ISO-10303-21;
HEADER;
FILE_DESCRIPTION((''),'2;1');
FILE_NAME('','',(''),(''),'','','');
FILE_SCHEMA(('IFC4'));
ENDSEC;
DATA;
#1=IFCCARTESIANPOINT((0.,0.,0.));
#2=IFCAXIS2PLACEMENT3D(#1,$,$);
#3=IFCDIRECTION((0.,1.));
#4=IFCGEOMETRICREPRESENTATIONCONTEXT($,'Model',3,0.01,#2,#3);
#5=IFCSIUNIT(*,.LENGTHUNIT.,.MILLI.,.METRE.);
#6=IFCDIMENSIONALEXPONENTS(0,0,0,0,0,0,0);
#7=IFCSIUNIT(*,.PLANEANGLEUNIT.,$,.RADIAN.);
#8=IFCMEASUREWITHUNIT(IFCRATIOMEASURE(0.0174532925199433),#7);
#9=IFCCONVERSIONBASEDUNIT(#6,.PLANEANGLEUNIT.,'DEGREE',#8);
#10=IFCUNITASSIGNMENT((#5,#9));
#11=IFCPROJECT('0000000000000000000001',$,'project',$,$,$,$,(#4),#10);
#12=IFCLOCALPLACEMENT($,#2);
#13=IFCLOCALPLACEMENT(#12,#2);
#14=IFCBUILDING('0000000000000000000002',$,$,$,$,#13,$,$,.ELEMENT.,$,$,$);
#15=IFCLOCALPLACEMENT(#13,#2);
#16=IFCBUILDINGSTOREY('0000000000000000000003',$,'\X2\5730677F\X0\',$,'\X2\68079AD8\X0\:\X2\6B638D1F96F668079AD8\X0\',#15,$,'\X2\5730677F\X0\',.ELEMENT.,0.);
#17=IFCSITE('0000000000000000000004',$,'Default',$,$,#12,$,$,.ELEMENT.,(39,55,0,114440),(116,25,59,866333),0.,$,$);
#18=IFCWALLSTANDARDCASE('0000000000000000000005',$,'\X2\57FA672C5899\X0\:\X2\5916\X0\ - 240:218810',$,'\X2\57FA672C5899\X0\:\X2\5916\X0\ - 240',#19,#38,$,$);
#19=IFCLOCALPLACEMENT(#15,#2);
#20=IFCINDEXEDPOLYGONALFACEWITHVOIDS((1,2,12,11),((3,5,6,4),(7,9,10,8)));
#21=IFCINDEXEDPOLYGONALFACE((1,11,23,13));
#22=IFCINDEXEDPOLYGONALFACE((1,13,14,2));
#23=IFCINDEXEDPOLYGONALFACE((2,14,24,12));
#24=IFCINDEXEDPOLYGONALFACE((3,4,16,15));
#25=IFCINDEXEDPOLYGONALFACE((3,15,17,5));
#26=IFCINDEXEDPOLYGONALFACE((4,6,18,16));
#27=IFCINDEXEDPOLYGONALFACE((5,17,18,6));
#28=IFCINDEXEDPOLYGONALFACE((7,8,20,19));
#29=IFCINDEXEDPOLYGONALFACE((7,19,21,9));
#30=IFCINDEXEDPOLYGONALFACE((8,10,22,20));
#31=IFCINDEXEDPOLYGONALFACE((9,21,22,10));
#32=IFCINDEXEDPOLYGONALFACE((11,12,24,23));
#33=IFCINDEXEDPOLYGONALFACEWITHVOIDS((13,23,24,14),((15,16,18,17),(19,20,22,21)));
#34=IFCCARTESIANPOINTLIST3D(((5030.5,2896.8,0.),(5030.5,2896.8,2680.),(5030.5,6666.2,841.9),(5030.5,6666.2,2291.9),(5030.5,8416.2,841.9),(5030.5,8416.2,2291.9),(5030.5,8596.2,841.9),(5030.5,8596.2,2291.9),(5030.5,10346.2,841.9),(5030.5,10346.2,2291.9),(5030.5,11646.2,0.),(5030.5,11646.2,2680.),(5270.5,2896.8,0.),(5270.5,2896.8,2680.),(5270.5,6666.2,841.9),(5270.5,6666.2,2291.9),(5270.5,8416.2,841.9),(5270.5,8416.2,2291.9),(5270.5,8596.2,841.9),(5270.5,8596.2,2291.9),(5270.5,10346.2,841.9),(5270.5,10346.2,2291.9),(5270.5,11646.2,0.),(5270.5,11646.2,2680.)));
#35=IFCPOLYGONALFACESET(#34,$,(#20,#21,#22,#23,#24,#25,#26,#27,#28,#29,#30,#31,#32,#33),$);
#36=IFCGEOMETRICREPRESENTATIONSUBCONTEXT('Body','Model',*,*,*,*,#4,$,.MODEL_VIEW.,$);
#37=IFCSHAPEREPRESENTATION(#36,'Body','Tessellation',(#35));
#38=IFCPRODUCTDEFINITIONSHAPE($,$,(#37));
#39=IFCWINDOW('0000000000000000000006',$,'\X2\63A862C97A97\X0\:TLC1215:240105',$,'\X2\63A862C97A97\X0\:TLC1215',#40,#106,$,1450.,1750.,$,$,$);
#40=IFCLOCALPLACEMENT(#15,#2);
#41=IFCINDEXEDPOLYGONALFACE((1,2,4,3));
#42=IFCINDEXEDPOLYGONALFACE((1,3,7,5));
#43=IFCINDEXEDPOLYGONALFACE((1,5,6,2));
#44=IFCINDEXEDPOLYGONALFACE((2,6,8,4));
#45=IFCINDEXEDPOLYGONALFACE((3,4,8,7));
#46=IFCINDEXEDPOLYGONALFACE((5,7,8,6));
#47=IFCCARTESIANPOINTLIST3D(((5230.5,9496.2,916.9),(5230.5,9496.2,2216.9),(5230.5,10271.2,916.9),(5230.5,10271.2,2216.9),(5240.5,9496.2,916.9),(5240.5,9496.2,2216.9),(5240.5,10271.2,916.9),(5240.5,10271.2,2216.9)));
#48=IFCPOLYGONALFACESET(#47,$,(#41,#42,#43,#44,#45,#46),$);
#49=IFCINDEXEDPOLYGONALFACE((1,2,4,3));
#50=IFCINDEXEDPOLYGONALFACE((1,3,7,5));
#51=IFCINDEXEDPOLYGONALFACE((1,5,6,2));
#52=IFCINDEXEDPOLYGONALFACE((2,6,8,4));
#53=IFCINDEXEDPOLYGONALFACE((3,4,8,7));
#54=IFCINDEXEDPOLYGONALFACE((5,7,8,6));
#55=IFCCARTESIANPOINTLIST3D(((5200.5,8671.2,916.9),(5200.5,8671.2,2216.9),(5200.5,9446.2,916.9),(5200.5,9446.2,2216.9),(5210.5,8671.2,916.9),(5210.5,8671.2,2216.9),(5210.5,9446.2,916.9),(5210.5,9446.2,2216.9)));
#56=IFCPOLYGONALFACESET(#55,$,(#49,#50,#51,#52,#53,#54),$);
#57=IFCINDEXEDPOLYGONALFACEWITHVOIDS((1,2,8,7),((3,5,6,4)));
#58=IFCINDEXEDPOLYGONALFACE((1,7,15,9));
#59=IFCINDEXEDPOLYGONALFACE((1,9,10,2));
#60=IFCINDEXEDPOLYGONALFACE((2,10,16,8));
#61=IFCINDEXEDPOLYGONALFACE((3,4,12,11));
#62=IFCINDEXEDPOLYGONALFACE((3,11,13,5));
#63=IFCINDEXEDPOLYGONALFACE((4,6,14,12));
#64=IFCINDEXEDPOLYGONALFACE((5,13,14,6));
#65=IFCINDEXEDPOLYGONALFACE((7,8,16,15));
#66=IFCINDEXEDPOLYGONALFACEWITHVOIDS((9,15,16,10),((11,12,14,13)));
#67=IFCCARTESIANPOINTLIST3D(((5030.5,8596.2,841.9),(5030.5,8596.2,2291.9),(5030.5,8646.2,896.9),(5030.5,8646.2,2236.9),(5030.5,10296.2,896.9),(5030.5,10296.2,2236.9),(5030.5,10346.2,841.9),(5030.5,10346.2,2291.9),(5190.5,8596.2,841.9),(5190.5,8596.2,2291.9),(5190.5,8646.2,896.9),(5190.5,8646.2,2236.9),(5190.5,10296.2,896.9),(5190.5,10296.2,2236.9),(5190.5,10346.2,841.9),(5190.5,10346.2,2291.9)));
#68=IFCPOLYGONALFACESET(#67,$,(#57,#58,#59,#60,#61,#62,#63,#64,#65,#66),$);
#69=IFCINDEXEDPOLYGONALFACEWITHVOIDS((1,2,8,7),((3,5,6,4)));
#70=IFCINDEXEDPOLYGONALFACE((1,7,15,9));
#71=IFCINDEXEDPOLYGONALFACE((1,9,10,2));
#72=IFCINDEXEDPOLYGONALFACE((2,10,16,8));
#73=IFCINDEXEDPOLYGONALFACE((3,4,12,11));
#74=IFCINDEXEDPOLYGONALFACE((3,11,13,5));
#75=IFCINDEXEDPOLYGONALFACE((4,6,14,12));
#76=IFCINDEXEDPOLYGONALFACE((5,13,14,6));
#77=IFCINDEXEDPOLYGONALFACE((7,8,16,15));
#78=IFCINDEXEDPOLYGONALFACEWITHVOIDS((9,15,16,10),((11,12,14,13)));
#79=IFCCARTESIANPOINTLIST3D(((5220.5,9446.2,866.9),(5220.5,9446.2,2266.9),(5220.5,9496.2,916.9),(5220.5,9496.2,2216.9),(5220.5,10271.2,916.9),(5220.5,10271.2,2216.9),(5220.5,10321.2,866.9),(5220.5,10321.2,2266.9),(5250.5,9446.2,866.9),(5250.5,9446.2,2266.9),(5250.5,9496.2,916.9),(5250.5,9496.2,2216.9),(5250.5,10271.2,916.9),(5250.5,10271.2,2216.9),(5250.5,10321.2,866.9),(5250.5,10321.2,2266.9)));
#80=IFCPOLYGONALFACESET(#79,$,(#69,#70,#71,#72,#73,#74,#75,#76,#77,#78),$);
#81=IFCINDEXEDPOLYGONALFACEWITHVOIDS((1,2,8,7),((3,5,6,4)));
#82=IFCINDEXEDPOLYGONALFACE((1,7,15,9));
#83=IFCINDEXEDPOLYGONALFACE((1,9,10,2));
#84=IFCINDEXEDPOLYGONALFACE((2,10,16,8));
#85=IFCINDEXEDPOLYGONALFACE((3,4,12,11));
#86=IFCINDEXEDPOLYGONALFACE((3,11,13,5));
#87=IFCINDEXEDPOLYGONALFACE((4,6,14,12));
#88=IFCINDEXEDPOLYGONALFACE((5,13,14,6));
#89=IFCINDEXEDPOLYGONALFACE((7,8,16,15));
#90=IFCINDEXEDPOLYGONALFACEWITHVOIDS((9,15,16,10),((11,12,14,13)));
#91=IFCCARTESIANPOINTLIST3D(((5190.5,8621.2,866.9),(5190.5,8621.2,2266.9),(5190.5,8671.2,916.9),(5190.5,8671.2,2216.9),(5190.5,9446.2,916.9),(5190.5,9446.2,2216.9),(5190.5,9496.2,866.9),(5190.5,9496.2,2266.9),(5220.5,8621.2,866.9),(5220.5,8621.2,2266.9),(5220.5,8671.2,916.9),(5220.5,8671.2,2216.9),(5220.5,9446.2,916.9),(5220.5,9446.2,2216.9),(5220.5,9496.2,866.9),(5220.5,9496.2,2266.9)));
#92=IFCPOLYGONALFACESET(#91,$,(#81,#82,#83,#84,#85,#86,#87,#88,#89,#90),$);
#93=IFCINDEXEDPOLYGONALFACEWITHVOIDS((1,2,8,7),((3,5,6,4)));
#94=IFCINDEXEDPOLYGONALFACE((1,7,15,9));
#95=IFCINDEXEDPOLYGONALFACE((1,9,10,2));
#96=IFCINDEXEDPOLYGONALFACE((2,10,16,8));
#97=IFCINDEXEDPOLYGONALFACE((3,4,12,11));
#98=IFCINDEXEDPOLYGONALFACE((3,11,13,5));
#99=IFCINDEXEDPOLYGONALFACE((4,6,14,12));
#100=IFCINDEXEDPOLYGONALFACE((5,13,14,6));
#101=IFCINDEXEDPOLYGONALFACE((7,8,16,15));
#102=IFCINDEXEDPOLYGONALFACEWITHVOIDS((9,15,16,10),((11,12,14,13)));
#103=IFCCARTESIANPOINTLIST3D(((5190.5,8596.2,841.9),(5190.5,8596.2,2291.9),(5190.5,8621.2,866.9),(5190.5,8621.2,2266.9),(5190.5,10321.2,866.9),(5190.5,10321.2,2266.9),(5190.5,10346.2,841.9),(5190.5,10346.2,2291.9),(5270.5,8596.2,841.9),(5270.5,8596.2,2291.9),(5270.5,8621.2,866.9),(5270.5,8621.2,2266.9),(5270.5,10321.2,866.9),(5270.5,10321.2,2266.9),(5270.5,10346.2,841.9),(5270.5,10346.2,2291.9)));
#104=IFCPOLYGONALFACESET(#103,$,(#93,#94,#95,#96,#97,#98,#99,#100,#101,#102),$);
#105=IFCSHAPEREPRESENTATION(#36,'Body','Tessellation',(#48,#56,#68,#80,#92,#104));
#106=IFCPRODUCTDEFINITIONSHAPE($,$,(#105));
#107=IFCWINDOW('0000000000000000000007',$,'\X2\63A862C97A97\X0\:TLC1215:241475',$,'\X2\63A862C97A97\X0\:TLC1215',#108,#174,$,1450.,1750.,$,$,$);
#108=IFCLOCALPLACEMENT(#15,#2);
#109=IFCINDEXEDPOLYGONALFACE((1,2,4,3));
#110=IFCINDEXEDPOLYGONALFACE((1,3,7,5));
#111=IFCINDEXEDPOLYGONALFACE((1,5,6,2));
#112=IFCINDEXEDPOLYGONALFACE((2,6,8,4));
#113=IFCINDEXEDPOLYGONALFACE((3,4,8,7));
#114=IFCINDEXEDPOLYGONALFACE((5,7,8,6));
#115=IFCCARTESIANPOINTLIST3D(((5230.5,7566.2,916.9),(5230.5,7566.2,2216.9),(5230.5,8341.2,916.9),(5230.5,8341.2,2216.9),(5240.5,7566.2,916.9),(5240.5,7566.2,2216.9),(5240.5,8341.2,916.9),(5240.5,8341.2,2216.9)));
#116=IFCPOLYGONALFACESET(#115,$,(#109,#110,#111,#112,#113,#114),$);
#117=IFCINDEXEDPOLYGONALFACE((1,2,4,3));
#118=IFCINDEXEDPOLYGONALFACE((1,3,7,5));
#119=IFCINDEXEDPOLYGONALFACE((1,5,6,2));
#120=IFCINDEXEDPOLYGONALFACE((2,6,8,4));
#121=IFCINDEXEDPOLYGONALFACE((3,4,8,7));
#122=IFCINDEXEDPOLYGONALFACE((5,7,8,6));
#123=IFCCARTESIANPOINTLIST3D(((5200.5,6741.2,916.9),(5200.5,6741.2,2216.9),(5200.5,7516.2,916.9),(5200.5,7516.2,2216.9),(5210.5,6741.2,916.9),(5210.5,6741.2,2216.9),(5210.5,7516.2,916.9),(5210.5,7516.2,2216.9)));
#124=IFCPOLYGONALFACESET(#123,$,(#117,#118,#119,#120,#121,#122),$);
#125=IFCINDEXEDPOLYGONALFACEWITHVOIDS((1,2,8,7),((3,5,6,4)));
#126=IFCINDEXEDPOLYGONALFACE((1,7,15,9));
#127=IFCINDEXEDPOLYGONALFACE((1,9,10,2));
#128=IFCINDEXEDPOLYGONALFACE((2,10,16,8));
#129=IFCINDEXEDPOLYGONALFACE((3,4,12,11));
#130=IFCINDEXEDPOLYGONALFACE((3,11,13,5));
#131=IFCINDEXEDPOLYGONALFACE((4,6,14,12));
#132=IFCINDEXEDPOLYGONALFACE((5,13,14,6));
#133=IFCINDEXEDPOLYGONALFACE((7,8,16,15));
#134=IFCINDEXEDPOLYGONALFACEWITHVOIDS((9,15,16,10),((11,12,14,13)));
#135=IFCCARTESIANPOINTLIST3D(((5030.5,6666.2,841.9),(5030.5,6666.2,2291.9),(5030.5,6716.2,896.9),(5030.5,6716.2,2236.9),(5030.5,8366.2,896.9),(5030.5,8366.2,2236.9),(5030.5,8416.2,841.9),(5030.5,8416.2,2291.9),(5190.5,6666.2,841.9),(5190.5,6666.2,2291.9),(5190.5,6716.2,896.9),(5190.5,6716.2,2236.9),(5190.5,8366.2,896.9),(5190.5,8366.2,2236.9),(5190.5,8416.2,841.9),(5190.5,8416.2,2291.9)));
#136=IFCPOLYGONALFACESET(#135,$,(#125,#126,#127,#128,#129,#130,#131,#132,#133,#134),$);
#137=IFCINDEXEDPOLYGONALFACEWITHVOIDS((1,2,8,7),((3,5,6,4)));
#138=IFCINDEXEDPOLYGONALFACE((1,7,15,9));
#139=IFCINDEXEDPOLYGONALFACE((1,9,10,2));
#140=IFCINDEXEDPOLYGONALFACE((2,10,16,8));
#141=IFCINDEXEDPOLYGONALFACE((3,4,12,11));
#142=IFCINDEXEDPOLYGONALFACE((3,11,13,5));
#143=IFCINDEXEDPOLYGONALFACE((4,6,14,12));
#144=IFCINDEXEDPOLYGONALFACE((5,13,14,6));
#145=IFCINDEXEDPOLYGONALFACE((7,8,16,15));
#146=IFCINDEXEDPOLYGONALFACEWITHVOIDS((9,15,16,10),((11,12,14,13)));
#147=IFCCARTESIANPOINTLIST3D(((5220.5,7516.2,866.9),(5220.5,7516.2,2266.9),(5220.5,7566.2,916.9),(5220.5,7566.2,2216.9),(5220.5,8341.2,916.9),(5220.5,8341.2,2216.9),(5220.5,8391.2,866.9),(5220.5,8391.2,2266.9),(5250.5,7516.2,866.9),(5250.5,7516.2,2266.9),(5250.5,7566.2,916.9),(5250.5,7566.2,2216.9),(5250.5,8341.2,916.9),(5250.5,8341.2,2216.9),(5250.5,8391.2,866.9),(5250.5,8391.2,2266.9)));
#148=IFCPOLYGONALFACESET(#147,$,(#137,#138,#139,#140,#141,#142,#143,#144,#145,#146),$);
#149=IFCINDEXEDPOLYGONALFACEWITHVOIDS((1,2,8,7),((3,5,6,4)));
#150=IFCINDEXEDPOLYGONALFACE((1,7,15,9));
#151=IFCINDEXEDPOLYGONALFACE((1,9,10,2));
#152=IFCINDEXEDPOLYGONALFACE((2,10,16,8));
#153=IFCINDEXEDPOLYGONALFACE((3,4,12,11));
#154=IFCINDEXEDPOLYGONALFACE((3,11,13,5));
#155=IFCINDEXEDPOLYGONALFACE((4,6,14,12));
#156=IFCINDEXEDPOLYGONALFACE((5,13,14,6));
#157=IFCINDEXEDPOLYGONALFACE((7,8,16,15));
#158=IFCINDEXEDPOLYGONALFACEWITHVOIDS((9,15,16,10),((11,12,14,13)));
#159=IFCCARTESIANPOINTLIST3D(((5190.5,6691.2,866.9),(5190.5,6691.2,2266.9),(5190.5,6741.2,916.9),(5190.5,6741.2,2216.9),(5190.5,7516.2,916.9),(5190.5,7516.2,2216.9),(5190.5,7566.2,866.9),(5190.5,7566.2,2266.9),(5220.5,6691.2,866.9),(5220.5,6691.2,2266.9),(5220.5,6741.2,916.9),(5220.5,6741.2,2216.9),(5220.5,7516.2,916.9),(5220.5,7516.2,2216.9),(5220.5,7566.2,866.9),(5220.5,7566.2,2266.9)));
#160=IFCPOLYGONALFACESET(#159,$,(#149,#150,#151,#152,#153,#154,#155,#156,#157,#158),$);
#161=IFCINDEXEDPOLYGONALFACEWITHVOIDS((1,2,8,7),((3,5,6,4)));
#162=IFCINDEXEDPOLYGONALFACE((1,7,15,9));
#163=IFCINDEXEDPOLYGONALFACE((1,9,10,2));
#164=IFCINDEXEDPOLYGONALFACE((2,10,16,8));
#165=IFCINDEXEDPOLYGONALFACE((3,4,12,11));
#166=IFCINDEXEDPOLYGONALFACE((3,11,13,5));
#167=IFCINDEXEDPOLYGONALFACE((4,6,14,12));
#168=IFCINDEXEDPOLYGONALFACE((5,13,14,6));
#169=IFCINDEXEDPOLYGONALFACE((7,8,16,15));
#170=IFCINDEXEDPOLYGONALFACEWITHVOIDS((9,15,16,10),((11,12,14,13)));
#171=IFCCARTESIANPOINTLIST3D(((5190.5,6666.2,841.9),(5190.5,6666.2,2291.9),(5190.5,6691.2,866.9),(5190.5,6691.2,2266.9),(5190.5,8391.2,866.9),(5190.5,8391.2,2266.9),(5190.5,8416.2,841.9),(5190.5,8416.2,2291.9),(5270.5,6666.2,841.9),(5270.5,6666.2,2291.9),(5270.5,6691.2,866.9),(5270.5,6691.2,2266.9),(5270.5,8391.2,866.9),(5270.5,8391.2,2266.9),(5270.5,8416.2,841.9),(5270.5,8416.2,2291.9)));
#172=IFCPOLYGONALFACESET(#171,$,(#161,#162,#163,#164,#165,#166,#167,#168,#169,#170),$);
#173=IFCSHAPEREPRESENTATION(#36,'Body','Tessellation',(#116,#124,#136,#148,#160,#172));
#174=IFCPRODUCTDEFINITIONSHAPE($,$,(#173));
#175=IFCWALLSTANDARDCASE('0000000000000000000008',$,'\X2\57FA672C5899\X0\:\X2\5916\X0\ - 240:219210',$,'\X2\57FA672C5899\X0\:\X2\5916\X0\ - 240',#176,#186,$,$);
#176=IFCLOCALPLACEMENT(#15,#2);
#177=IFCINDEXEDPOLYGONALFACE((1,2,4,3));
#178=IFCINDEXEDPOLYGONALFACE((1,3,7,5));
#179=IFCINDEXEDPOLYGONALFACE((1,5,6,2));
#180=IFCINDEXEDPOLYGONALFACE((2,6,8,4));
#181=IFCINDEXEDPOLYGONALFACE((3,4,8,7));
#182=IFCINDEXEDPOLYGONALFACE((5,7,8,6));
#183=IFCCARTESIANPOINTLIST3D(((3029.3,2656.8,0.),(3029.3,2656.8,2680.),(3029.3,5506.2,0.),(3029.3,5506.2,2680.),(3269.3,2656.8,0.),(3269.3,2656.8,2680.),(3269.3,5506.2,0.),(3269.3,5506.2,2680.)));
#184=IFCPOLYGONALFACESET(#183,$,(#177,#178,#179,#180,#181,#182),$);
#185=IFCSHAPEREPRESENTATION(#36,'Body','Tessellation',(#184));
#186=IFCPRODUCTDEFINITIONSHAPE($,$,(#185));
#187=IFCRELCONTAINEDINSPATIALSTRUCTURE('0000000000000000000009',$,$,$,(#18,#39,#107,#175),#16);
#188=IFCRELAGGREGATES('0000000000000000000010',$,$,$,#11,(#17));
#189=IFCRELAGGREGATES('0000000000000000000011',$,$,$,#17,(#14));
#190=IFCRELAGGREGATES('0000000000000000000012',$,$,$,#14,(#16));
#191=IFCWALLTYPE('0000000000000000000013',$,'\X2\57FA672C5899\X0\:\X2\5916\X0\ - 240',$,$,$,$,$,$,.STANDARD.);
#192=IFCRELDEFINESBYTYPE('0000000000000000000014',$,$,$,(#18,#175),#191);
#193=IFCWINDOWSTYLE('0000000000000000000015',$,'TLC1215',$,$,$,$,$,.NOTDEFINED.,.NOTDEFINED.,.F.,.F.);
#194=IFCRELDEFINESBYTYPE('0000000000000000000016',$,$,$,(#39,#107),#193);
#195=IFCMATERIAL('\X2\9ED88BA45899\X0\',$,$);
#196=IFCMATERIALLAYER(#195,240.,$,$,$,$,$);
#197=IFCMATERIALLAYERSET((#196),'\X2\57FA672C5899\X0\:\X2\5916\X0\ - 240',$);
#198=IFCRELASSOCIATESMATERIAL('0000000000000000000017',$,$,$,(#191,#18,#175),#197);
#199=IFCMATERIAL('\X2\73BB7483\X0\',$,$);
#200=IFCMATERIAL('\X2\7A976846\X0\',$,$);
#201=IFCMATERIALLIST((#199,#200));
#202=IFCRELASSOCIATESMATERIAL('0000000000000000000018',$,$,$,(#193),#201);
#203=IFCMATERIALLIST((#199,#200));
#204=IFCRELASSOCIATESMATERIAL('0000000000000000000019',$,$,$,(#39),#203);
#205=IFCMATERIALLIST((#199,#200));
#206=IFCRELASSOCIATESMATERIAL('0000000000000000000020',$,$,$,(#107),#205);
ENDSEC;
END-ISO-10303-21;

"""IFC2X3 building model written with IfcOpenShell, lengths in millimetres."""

from ifc_helpers import new_model, entity, si_unit, converted_unit, direction, frame, frame_2d, origin, origin_2d_with_axis, place, context, subcontext, project, spatial, polyline, rectangle, outline, extrude, source, transform, mapped, material, material_list, layer, layer_set, layer_usage, type_object, type_shapes, element, fill, save


model = new_model("IFC2X3")

# Units and contexts
model_context = context("Model", 3, precision=0.01, world=origin(), true_north=direction((0.0, 1.0)))
body_context = subcontext(model_context, "Body", "Model", "MODEL_VIEW")
ifc_project = project(units=[si_unit("LENGTHUNIT", "METRE", prefix="MILLI"), converted_unit("PLANEANGLEUNIT", "DEGREE", entity("IfcRatioMeasure", 0.0174532925199433), si_unit("PLANEANGLEUNIT", "RADIAN"), dimensions=[0, 0, 0, 0, 0, 0, 0])], contexts=[model_context])

# Site, building, storey
site_placement = place(None, origin())
site = spatial("IfcSite", under=ifc_project, at=site_placement, Name="Default", CompositionType="ELEMENT", RefLatitude=(39, 55, 0, 114440), RefLongitude=(116, 25, 59, 866333), RefElevation=0.0)
building_placement = place(site_placement, origin())
building = spatial("IfcBuilding", under=site, at=building_placement, CompositionType="ELEMENT")
storey_placement = place(building_placement, origin())
storey = spatial("IfcBuildingStorey", under=building, at=storey_placement, Name="地板", ObjectType="标高:正负零标高", LongName="地板", CompositionType="ELEMENT", Elevation=0.0)

# Wall, openings, windows
ifc_material_1 = material(Name="默认墙")
ifc_layer_1 = layer(ifc_material_1, 240.0)
ifc_layer_set_1 = layer_set([ifc_layer_1], Name="基本墙:外 - 240")
ifc_layer_usage_1 = layer_usage(ifc_layer_set_1, "AXIS2", "NEGATIVE", 120.0)
wall_type_1 = type_object("IfcWallType", Name="基本墙:外 - 240", PredefinedType="STANDARD", material=ifc_layer_set_1)
wall_1_placement = place(storey_placement, frame((5150.5, 11646.2, 0.0), z_axis=(0.0, 0.0, 1.0), x_axis=(0.0, -1.0, 0.0)))
wall_1 = element("IfcWallStandardCase", 1, at=wall_1_placement, inside=storey, type_object=wall_type_1, material=ifc_layer_usage_1, Name="基本墙:外 - 240:218810", ObjectType="基本墙:外 - 240", context=body_context, shape_type="SweptSolid", body=[
    extrude(rectangle(XDim=8749.4, YDim=240.0, at=frame_2d((4374.7, 0.0), x_axis=(-1.0, 0.0))), origin(), (0.0, 0.0, 1.0), 2680.0),
])
opening_1_placement = place(wall_1_placement, frame((3230.0, -120.0, 841.9)))
opening_1 = element("IfcOpeningElement", 2, at=opening_1_placement, cuts=wall_1, ObjectType="Opening", context=body_context, shape_type="SweptSolid", body=[
    extrude(rectangle(XDim=1450.0, YDim=1750.0, at=frame_2d((725.0, 875.0), x_axis=(-1.0, 0.0))), frame((0.0, 0.0, 0.0), z_axis=(0.0, 1.0, 0.0), x_axis=(0.0, 0.0, 1.0)), (0.0, 0.0, 1.0), 240.0),
])
opening_2_placement = place(wall_1_placement, frame((1300.0, -120.0, 841.9)))
opening_2 = element("IfcOpeningElement", 3, at=opening_2_placement, cuts=wall_1, ObjectType="Opening", context=body_context, shape_type="SweptSolid", body=[
    extrude(rectangle(XDim=1450.0, YDim=1750.0, at=frame_2d((725.0, 875.0), x_axis=(-1.0, 0.0))), frame((0.0, 0.0, 0.0), z_axis=(0.0, 1.0, 0.0), x_axis=(0.0, 0.0, 1.0)), (0.0, 0.0, 1.0), 240.0),
])
ifc_material_2 = material(Name="玻璃")
ifc_material_3 = material(Name="窗框")
ifc_material_list_1 = material_list([ifc_material_2, ifc_material_3])
ifc_material_list_2 = material_list([ifc_material_2, ifc_material_3])
window_style = type_object("IfcWindowStyle", Name="TLC1215", ConstructionType="NOTDEFINED", OperationType="NOTDEFINED", ParameterTakesPrecedence=False, Sizeable=False, material=ifc_material_list_2)
shared_shape_1 = source(origin(), body_context, "Body", "SweptSolid", [
    extrude(rectangle(XDim=10.0, YDim=775.0, at=frame_2d((0.0, 0.0), x_axis=(1.0, 0.0))), frame((462.5, 205.0, 75.0), z_axis=(0.0, 0.0, 1.0), x_axis=(0.0, -1.0, 0.0)), (0.0, 0.0, 1.0), 1300.0),
    extrude(rectangle(XDim=10.0, YDim=775.0, at=origin_2d_with_axis()), frame((1287.5, 175.0, 75.0), z_axis=(0.0, 0.0, 1.0), x_axis=(0.0, -1.0, 0.0)), (0.0, 0.0, 1.0), 1300.0),
    extrude(outline(polyline([(-875.0, -725.0), (875.0, -725.0), (875.0, 725.0), (-875.0, 725.0), (-875.0, -725.0)]), holes=[polyline([(825.0, -670.0), (-825.0, -670.0), (-825.0, 670.0), (825.0, 670.0), (825.0, -670.0)])]), frame((875.0, 0.0, 725.0), z_axis=(0.0, 1.0, 0.0), x_axis=(1.0, 0.0, 0.0)), (0.0, 0.0, 1.0), 160.0),
    extrude(outline(polyline([(-437.5, -700.0), (437.5, -700.0), (437.5, 700.0), (-437.5, 700.0), (-437.5, -700.0)]), holes=[polyline([(-387.5, -650.0), (-387.5, 650.0), (387.5, 650.0), (387.5, -650.0), (-387.5, -650.0)])]), frame((462.5, 190.0, 725.0), z_axis=(0.0, 1.0, 0.0), x_axis=(-1.0, 0.0, 0.0)), (0.0, 0.0, 1.0), 30.0),
    extrude(outline(polyline([(-437.5, -700.0), (437.5, -700.0), (437.5, 700.0), (-437.5, 700.0), (-437.5, -700.0)]), holes=[polyline([(-387.5, -650.0), (-387.5, 650.0), (387.5, 650.0), (387.5, -650.0), (-387.5, -650.0)])]), frame((1287.5, 160.0, 725.0), z_axis=(0.0, 1.0, 0.0), x_axis=(1.0, 0.0, 0.0)), (0.0, 0.0, 1.0), 30.0),
    extrude(outline(polyline([(-875.0, -725.0), (875.0, -725.0), (875.0, 725.0), (-875.0, 725.0), (-875.0, -725.0)]), holes=[polyline([(-850.0, 700.0), (850.0, 700.0), (850.0, -700.0), (-850.0, -700.0), (-850.0, 700.0)])]), frame((875.0, 160.0, 725.0), z_axis=(0.0, 1.0, 0.0), x_axis=(1.0, 0.0, 0.0)), (0.0, 0.0, 1.0), 80.0),
])
type_shapes(window_style, [shared_shape_1])
window_1_placement = place(opening_2_placement, origin())
window_1 = element("IfcWindow", 4, at=window_1_placement, inside=storey, type_object=window_style, material=ifc_material_list_1, Name="推拉窗:TLC1215:240105", ObjectType="推拉窗:TLC1215", OverallHeight=1450.0, OverallWidth=1750.0, context=body_context, shape_type="MappedRepresentation", body=[
    mapped(shared_shape_1, transform((0.0, 0.0, 0.0), scale=1.0)),
])
fill(opening_2, window_1)
ifc_material_list_3 = material_list([ifc_material_2, ifc_material_3])
window_2_placement = place(opening_1_placement, origin())
window_2 = element("IfcWindow", 5, at=window_2_placement, inside=storey, type_object=window_style, material=ifc_material_list_3, Name="推拉窗:TLC1215:241475", ObjectType="推拉窗:TLC1215", OverallHeight=1450.0, OverallWidth=1750.0, context=body_context, shape_type="MappedRepresentation", body=[
    mapped(shared_shape_1, transform((0.0, 0.0, 0.0), scale=1.0)),
])
fill(opening_1, window_2)

# Wall
ifc_layer_usage_2 = layer_usage(ifc_layer_set_1, "AXIS2", "NEGATIVE", 120.0)
wall_2_placement = place(storey_placement, frame((3149.3, 5506.2, 0.0), z_axis=(0.0, 0.0, 1.0), x_axis=(0.0, -1.0, 0.0)))
element("IfcWallStandardCase", 6, at=wall_2_placement, inside=storey, type_object=wall_type_1, material=ifc_layer_usage_2, Name="基本墙:外 - 240:219210", ObjectType="基本墙:外 - 240", context=body_context, shape_type="SweptSolid", body=[
    extrude(rectangle(XDim=2849.4, YDim=240.0, at=frame_2d((1424.7, 0.0), x_axis=(-1.0, 0.0))), origin(), (0.0, 0.0, 1.0), 2680.0),
])

save(model, "model.ifc")
